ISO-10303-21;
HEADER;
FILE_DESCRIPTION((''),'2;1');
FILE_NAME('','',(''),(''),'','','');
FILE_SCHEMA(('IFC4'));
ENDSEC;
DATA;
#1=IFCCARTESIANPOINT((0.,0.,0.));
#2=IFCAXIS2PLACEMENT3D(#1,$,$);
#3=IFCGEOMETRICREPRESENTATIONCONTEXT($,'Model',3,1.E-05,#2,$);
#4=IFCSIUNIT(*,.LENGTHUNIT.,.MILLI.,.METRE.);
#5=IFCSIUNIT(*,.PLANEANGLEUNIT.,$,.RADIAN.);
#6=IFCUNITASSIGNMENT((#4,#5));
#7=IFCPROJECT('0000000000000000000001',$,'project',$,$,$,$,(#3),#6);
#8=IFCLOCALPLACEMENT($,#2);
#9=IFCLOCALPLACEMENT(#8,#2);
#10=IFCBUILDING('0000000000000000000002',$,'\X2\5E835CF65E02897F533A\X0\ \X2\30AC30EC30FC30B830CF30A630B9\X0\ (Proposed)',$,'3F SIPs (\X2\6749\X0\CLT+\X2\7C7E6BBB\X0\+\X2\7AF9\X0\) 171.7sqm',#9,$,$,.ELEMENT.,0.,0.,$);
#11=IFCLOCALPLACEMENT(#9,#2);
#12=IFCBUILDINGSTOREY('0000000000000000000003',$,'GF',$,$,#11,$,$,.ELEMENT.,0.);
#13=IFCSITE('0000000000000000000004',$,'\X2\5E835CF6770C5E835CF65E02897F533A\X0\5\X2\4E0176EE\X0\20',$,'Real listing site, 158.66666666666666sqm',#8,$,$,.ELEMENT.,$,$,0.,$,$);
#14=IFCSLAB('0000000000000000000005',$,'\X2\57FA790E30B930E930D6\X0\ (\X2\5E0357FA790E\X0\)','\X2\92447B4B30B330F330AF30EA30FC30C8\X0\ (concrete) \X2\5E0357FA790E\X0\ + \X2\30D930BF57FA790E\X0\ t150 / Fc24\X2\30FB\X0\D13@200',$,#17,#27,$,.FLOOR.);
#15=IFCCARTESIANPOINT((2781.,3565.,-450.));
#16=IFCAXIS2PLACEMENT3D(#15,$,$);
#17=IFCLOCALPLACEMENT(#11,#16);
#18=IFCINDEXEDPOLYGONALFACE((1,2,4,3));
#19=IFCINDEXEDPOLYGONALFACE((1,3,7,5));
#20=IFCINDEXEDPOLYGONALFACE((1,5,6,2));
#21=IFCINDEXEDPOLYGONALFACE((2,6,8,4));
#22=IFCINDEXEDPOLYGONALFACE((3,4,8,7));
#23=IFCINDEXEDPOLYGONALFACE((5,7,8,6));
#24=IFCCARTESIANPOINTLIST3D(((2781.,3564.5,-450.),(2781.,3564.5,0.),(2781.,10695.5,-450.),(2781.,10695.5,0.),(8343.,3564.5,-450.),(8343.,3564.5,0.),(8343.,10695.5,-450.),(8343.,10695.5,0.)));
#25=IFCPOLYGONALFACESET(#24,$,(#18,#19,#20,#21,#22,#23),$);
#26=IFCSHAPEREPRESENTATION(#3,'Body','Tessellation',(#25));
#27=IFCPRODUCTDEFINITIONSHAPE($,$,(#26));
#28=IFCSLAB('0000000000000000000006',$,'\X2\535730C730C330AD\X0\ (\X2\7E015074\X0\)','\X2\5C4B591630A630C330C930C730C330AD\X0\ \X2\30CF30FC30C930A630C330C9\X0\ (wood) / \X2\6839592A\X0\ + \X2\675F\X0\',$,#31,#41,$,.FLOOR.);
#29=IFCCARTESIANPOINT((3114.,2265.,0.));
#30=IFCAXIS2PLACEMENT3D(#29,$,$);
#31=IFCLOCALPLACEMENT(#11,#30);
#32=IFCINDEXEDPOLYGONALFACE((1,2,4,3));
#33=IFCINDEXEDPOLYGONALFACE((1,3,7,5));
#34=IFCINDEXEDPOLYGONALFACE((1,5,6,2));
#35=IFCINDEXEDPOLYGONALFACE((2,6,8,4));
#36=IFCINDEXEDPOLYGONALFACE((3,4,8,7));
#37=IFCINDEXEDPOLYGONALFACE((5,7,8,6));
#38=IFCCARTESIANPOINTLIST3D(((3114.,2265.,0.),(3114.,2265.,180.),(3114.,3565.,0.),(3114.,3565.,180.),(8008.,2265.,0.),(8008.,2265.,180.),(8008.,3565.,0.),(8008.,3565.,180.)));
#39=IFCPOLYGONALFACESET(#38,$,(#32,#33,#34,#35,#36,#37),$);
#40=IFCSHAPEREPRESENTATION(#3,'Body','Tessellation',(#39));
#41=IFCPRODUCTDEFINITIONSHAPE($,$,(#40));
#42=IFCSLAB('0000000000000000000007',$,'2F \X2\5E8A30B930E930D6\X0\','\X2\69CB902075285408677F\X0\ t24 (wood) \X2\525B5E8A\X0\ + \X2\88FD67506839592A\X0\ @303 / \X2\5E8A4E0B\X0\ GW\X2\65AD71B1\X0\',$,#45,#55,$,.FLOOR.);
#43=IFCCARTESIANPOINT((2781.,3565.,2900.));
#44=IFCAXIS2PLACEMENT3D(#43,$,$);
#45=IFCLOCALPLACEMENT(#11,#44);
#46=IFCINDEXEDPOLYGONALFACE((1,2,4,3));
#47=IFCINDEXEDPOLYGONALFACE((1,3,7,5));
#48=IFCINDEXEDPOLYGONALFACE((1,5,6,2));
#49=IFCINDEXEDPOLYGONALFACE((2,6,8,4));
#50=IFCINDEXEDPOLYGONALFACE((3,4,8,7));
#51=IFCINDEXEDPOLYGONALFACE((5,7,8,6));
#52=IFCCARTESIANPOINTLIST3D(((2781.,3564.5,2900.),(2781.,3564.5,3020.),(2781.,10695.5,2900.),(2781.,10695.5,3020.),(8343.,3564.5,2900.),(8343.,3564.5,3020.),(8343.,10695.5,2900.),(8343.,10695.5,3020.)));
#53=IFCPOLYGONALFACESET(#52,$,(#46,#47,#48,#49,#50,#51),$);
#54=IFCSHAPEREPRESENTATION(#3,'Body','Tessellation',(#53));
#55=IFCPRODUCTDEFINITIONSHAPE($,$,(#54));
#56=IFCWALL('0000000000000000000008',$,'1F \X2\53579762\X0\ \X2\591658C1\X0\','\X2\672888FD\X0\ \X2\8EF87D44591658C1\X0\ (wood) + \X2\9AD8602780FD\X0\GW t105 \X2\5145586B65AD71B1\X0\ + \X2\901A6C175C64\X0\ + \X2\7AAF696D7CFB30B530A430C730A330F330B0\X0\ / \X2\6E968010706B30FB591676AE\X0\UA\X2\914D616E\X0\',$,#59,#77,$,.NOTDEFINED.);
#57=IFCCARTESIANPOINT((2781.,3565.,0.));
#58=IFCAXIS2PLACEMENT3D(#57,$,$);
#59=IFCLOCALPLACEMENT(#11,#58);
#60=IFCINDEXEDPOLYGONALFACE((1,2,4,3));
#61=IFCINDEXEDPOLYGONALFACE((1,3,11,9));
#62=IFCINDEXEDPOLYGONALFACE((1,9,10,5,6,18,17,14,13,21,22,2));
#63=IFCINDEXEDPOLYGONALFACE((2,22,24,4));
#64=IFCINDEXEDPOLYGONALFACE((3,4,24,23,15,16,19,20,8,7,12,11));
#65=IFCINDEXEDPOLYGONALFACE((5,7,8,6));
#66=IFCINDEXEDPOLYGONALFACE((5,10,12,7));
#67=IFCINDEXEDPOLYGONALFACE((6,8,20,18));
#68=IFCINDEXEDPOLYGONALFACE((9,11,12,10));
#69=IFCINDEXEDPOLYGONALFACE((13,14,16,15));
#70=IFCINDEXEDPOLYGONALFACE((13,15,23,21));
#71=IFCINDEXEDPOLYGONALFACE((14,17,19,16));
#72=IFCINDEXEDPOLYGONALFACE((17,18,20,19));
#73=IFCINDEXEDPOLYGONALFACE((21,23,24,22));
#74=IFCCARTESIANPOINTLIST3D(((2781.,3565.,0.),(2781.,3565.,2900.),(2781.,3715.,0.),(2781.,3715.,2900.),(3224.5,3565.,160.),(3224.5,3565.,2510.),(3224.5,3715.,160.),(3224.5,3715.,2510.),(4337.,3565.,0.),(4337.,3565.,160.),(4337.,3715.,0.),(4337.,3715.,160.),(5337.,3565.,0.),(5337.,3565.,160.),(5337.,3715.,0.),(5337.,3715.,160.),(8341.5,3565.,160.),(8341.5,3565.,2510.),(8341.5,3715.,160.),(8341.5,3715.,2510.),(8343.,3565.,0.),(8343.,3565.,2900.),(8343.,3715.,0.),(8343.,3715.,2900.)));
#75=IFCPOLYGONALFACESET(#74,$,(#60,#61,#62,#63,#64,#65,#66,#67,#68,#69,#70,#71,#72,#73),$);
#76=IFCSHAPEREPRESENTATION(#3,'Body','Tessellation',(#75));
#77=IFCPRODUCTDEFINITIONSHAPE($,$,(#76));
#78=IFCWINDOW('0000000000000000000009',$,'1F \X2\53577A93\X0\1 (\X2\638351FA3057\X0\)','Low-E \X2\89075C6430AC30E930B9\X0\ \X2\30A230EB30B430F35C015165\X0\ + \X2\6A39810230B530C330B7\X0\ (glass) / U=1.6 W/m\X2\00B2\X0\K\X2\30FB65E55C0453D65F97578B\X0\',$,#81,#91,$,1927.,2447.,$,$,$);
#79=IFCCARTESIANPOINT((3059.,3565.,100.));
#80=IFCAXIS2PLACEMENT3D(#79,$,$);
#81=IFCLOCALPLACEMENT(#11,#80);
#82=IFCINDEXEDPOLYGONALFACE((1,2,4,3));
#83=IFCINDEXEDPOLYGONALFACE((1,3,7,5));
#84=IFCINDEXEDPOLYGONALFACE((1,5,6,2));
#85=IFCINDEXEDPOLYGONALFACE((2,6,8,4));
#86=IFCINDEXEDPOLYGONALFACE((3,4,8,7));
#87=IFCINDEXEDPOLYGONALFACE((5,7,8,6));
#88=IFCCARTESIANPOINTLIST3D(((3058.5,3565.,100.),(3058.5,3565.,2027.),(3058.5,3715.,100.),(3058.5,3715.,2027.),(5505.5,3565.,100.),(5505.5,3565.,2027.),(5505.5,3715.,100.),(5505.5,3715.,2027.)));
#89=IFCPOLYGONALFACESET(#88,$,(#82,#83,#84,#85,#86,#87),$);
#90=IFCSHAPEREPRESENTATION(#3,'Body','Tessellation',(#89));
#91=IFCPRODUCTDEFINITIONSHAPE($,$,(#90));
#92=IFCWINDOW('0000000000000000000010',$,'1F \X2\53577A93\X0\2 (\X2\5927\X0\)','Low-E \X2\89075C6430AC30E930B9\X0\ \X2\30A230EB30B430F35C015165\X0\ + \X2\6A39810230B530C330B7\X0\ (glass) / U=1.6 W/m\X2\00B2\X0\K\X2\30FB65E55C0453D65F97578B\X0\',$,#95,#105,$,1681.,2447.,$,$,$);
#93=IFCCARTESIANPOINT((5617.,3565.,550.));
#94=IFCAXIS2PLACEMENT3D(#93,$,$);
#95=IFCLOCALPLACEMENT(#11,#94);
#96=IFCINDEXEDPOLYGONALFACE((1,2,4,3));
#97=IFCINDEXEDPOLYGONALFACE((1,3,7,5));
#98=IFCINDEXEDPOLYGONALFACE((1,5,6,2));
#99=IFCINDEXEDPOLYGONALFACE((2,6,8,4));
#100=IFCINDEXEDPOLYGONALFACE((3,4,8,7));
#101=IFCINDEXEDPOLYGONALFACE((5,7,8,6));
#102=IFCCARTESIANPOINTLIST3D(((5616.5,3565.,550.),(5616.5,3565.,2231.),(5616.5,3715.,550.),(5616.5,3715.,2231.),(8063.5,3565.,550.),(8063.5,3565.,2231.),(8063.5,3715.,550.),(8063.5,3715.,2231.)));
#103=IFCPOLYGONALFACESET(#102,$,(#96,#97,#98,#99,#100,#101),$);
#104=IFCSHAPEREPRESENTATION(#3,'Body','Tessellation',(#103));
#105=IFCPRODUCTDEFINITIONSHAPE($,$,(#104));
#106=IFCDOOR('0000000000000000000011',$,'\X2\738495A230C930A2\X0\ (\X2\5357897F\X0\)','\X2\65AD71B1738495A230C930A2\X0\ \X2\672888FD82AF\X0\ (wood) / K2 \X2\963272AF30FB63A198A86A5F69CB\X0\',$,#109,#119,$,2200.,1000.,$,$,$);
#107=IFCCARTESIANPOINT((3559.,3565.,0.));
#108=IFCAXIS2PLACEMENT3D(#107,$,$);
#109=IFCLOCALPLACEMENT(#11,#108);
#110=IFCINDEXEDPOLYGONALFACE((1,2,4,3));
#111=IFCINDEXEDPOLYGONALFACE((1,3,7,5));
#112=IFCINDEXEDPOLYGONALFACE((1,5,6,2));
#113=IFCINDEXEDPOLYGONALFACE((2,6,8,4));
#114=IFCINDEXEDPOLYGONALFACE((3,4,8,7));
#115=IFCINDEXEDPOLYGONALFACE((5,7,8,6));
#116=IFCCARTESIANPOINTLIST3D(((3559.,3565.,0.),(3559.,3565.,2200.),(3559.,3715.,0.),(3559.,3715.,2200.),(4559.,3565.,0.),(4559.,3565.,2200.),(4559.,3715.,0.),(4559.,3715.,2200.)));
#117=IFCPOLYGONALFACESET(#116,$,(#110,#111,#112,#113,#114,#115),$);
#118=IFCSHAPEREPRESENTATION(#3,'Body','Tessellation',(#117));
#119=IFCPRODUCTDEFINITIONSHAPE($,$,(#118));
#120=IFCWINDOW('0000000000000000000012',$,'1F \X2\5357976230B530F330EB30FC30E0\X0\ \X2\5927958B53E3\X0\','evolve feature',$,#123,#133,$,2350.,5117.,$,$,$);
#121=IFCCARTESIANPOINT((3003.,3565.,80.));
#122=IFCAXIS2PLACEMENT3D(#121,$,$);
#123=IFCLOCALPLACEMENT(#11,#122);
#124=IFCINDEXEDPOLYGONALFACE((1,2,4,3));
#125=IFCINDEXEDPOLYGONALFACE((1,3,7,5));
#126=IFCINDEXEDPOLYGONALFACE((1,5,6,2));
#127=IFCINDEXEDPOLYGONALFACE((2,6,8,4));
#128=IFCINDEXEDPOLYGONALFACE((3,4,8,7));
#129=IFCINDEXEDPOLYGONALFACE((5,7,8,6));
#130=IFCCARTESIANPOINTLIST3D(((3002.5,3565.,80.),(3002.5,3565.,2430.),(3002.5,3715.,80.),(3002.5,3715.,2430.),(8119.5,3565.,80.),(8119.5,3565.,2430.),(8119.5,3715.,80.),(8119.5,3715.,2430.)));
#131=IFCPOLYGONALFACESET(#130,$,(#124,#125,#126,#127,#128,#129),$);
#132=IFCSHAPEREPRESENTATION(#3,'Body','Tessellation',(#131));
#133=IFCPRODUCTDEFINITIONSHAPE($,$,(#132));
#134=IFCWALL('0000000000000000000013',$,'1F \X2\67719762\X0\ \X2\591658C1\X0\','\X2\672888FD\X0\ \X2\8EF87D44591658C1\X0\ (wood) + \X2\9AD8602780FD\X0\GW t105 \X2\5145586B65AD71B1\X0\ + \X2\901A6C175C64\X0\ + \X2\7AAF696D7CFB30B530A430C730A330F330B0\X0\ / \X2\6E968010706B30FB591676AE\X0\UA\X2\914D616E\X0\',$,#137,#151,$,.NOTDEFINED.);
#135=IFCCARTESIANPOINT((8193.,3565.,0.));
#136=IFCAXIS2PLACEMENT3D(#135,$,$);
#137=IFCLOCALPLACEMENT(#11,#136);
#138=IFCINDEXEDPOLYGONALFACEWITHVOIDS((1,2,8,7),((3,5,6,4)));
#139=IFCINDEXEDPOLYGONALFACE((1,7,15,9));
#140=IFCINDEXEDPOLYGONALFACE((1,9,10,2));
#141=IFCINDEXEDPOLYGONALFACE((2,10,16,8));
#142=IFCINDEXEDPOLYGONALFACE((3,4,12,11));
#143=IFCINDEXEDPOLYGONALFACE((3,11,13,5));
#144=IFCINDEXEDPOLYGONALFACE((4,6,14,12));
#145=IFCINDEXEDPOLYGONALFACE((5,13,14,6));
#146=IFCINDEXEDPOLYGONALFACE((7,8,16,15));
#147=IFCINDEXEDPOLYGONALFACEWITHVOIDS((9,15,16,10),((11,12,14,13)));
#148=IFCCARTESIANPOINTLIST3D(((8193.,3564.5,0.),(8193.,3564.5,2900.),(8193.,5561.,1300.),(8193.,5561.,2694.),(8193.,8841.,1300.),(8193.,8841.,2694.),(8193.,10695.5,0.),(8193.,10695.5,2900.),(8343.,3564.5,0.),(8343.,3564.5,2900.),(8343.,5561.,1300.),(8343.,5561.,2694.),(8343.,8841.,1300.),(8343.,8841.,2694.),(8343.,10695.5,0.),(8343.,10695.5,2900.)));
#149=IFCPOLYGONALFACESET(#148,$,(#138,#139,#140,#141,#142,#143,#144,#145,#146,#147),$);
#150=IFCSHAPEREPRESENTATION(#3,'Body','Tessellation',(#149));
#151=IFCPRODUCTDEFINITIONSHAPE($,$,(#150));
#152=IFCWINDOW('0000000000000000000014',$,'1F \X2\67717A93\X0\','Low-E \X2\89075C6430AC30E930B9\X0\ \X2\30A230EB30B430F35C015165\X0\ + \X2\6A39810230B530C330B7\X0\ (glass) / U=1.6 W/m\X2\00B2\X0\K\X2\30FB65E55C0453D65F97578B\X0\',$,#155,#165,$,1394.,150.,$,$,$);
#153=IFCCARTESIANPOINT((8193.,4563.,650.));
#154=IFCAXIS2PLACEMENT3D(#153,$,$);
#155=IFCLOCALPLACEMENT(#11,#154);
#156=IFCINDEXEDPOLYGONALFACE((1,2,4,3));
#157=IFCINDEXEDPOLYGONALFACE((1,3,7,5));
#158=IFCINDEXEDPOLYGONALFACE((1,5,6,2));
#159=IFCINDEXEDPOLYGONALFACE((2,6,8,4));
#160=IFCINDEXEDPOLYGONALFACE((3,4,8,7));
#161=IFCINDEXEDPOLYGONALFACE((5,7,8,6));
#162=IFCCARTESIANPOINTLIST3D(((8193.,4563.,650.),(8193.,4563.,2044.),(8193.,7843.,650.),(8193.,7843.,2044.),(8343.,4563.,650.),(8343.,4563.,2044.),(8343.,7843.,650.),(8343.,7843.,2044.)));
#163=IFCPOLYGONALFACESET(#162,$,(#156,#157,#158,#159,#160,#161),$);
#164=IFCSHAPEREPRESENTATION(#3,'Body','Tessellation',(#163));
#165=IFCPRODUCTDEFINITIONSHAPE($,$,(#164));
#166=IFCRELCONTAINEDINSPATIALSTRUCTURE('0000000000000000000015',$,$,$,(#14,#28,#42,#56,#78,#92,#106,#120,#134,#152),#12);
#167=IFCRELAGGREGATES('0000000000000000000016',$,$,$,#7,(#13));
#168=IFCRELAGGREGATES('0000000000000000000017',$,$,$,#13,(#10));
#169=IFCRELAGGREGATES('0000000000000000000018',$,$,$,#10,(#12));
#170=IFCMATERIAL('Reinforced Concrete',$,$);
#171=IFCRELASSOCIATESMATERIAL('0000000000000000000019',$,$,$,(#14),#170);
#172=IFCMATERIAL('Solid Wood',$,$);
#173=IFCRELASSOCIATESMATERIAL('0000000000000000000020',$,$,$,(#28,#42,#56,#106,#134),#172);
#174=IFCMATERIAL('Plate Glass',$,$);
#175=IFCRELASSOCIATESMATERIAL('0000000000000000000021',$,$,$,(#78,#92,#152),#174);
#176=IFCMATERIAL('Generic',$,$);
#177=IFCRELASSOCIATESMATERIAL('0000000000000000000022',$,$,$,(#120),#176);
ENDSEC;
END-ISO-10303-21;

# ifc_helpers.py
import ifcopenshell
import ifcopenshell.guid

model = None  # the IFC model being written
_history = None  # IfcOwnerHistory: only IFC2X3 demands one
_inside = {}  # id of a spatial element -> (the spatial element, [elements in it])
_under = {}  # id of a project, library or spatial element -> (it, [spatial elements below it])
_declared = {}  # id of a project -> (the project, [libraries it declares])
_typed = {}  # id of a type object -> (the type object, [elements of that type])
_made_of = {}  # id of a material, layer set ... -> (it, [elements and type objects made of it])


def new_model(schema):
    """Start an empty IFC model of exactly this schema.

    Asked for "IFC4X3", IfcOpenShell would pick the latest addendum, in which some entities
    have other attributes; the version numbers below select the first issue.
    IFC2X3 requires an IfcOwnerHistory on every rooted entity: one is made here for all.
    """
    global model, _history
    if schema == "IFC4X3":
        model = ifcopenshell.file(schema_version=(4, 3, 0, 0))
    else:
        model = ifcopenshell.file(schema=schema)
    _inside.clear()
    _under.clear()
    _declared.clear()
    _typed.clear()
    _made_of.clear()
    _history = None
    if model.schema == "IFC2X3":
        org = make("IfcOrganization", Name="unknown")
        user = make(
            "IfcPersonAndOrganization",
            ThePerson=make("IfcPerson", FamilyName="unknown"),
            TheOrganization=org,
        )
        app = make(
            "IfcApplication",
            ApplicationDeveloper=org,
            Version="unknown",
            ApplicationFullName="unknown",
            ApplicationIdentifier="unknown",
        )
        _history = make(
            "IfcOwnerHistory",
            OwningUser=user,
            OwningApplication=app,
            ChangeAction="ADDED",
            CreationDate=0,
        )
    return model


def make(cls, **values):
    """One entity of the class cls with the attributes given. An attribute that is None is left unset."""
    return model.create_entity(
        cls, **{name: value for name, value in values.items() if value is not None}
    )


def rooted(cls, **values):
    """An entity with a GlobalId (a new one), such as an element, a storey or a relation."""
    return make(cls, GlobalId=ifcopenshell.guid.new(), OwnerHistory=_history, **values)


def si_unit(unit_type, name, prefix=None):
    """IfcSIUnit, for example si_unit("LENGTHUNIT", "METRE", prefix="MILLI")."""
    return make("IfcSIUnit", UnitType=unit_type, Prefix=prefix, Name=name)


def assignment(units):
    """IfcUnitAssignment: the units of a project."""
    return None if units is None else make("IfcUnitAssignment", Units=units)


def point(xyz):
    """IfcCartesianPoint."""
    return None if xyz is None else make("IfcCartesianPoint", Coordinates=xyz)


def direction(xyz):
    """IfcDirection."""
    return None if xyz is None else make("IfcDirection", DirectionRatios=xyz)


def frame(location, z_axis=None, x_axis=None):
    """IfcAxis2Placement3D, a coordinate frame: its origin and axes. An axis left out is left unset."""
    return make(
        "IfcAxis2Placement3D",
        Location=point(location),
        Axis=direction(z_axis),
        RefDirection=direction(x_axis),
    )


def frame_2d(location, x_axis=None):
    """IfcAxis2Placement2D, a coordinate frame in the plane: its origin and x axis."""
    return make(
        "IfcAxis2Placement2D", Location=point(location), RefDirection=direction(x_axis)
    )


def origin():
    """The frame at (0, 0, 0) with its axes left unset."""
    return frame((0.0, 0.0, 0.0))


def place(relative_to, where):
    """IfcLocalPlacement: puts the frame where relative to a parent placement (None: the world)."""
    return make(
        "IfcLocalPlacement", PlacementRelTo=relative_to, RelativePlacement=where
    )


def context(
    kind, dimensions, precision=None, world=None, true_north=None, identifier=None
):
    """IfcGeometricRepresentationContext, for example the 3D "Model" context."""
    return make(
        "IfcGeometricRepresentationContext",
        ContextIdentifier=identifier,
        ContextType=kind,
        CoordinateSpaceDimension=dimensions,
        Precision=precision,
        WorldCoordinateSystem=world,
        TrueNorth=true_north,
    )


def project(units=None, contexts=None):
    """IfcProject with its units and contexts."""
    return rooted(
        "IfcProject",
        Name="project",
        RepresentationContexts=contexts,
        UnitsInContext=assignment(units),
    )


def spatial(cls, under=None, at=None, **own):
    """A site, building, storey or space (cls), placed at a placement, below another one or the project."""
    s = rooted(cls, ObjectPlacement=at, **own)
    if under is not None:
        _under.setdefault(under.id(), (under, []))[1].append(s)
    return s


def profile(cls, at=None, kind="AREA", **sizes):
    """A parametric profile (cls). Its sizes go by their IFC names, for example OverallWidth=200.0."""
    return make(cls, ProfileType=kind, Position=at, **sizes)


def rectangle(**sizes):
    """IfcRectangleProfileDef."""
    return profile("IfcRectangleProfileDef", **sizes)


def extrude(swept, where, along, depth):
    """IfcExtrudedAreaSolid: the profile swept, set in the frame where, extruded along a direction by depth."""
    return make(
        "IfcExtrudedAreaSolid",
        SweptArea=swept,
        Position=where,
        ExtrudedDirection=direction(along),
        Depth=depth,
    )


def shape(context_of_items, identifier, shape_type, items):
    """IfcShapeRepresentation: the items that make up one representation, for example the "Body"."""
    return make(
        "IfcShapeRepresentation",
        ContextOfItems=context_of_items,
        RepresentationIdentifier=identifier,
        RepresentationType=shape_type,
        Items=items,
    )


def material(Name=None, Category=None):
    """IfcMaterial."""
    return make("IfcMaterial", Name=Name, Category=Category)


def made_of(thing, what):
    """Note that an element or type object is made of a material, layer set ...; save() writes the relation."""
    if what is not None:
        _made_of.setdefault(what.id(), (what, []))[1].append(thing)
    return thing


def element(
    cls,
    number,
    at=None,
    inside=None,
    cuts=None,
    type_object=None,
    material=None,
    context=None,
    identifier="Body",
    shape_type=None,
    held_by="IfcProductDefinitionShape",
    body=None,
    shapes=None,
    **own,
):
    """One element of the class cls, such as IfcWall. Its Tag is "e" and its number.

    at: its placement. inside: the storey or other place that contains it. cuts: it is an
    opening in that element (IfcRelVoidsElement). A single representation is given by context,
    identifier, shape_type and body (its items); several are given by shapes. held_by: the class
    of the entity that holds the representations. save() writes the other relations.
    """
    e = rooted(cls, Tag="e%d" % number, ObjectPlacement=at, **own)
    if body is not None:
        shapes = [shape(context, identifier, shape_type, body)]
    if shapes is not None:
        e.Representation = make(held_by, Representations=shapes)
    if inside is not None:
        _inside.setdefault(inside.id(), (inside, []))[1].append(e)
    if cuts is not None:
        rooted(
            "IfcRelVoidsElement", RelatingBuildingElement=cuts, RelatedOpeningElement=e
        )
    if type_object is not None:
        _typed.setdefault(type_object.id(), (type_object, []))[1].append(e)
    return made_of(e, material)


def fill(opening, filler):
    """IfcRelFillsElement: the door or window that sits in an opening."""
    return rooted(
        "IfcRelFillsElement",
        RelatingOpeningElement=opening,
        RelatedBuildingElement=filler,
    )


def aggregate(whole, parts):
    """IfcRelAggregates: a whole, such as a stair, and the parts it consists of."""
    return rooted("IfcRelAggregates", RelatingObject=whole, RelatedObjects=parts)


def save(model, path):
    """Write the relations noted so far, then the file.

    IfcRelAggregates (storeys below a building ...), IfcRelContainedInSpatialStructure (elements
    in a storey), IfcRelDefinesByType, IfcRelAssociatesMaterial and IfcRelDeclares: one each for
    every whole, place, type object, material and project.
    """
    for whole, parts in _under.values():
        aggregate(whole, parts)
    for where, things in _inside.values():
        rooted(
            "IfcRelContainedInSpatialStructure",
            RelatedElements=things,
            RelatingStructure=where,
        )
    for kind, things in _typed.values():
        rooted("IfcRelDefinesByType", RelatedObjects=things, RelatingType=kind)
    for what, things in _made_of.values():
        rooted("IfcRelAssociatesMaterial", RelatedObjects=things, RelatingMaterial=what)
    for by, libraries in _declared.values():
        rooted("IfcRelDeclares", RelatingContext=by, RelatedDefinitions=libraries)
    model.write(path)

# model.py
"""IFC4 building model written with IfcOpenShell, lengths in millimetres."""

from ifc_helpers import new_model, si_unit, frame, frame_2d, origin, place, context, project, spatial, rectangle, extrude, material, element, fill, save


model = new_model("IFC4")

# Units and contexts
model_context = context("Model", 3, precision=1e-05, world=origin())
ifc_project = project(units=[si_unit("LENGTHUNIT", "METRE", prefix="MILLI"), si_unit("PLANEANGLEUNIT", "RADIAN")], contexts=[model_context])

# Site, building, storey
site_placement = place(None, origin())
site = spatial("IfcSite", under=ifc_project, at=site_placement, Name="広島県広島市西区5丁目20", ObjectType="Real listing site, 158.66666666666666sqm", CompositionType="ELEMENT", RefElevation=0.0)
building_placement = place(site_placement, origin())
building = spatial("IfcBuilding", under=site, at=building_placement, Name="広島市西区 ガレージハウス (Proposed)", ObjectType="3F SIPs (杉CLT+籾殻+竹) 171.7sqm", CompositionType="ELEMENT", ElevationOfRefHeight=0.0, ElevationOfTerrain=0.0)
storey_placement = place(building_placement, origin())
storey = spatial("IfcBuildingStorey", under=building, at=storey_placement, Name="GF", CompositionType="ELEMENT", Elevation=0.0)

# Slabs
ifc_material_1 = material(Name="Reinforced Concrete")
slab_1_placement = place(storey_placement, frame((2781.0, 3565.0, -450.0)))
element("IfcSlab", 1, at=slab_1_placement, inside=storey, material=ifc_material_1, Name="基礎スラブ (布基礎)", Description="鉄筋コンクリート (concrete) 布基礎 + ベタ基礎 t150 / Fc24・D13@200", PredefinedType="FLOOR", context=model_context, shape_type="SweptSolid", body=[
    extrude(rectangle(XDim=5562.0, YDim=7131.0, at=frame_2d((2781.0, 3565.0))), frame((2781.0, 3565.0, -450.0)), (0.0, 0.0, 1.0), 450.0),
])
ifc_material_2 = material(Name="Solid Wood")
slab_2_placement = place(storey_placement, frame((3114.0, 2265.0, 0.0)))
element("IfcSlab", 2, at=slab_2_placement, inside=storey, material=ifc_material_2, Name="南デッキ (縁側)", Description="屋外ウッドデッキ ハードウッド (wood) / 根太 + 束", PredefinedType="FLOOR", context=model_context, shape_type="SweptSolid", body=[
    extrude(rectangle(XDim=4894.0, YDim=1300.0, at=frame_2d((2447.0, 650.0))), frame((3114.0, 2265.0, 0.0)), (0.0, 0.0, 1.0), 180.0),
])
slab_3_placement = place(storey_placement, frame((2781.0, 3565.0, 2900.0)))
element("IfcSlab", 3, at=slab_3_placement, inside=storey, material=ifc_material_2, Name="2F 床スラブ", Description="構造用合板 t24 (wood) 剛床 + 製材根太 @303 / 床下 GW断熱", PredefinedType="FLOOR", context=model_context, shape_type="SweptSolid", body=[
    extrude(rectangle(XDim=5562.0, YDim=7131.0, at=frame_2d((2781.0, 3565.0))), frame((2781.0, 3565.0, 2900.0)), (0.0, 0.0, 1.0), 120.0),
])

# Wall, openings, windows, door
wall_1_placement = place(storey_placement, frame((2781.0, 3565.0, 0.0)))
wall_1 = element("IfcWall", 4, at=wall_1_placement, inside=storey, material=ifc_material_2, Name="1F 南面 外壁", Description="木製 軸組外壁 (wood) + 高性能GW t105 充填断熱 + 通気層 + 窯業系サイディング / 準耐火・外皮UA配慮", PredefinedType="NOTDEFINED", context=model_context, shape_type="SweptSolid", body=[
    extrude(rectangle(XDim=5562.0, YDim=150.0, at=frame_2d((2781.0, 75.0))), frame((2781.0, 3565.0, 0.0)), (0.0, 0.0, 1.0), 2900.0),
])
opening_1_placement = place(storey_placement, frame((3059.0, 3565.0, 100.0)))
opening_1 = element("IfcOpeningElement", 5, at=opening_1_placement, cuts=wall_1, PredefinedType="NOTDEFINED", context=model_context, shape_type="SweptSolid", body=[
    extrude(rectangle(XDim=2447.0, YDim=150.0, at=frame_2d((1223.0, 75.0))), frame((3059.0, 3565.0, 100.0)), (0.0, 0.0, 1.0), 1927.0),
])
opening_2_placement = place(storey_placement, frame((5617.0, 3565.0, 550.0)))
opening_2 = element("IfcOpeningElement", 6, at=opening_2_placement, cuts=wall_1, PredefinedType="NOTDEFINED", context=model_context, shape_type="SweptSolid", body=[
    extrude(rectangle(XDim=2447.0, YDim=150.0, at=frame_2d((1223.0, 75.0))), frame((5617.0, 3565.0, 550.0)), (0.0, 0.0, 1.0), 1681.0),
])
opening_3_placement = place(storey_placement, frame((3559.0, 3565.0, 0.0)))
opening_3 = element("IfcOpeningElement", 7, at=opening_3_placement, cuts=wall_1, PredefinedType="NOTDEFINED", context=model_context, shape_type="SweptSolid", body=[
    extrude(rectangle(XDim=1000.0, YDim=150.0, at=frame_2d((500.0, 75.0))), frame((3559.0, 3565.0, 0.0)), (0.0, 0.0, 1.0), 2200.0),
])
opening_4_placement = place(storey_placement, frame((3003.0, 3565.0, 80.0)))
opening_4 = element("IfcOpeningElement", 8, at=opening_4_placement, cuts=wall_1, PredefinedType="NOTDEFINED", context=model_context, shape_type="SweptSolid", body=[
    extrude(rectangle(XDim=5117.0, YDim=150.0, at=frame_2d((2558.0, 75.0))), frame((3003.0, 3565.0, 80.0)), (0.0, 0.0, 1.0), 2350.0),
])
ifc_material_3 = material(Name="Plate Glass")
window_1_placement = place(storey_placement, frame((3059.0, 3565.0, 100.0)))
window_1 = element("IfcWindow", 9, at=window_1_placement, inside=storey, material=ifc_material_3, Name="1F 南窓1 (掃出し)", Description="Low-E 複層ガラス アルゴン封入 + 樹脂サッシ (glass) / U=1.6 W/m²K・日射取得型", OverallHeight=1927.0, OverallWidth=2447.0, context=model_context, shape_type="SweptSolid", body=[
    extrude(rectangle(XDim=2447.0, YDim=150.0, at=frame_2d((1223.0, 75.0))), frame((3059.0, 3565.0, 100.0)), (0.0, 0.0, 1.0), 1927.0),
])
fill(opening_1, window_1)
window_2_placement = place(storey_placement, frame((5617.0, 3565.0, 550.0)))
window_2 = element("IfcWindow", 10, at=window_2_placement, inside=storey, material=ifc_material_3, Name="1F 南窓2 (大)", Description="Low-E 複層ガラス アルゴン封入 + 樹脂サッシ (glass) / U=1.6 W/m²K・日射取得型", OverallHeight=1681.0, OverallWidth=2447.0, context=model_context, shape_type="SweptSolid", body=[
    extrude(rectangle(XDim=2447.0, YDim=150.0, at=frame_2d((1223.0, 75.0))), frame((5617.0, 3565.0, 550.0)), (0.0, 0.0, 1.0), 1681.0),
])
fill(opening_2, window_2)
door_placement = place(storey_placement, frame((3559.0, 3565.0, 0.0)))
door = element("IfcDoor", 11, at=door_placement, inside=storey, material=ifc_material_2, Name="玄関ドア (南西)", Description="断熱玄関ドア 木製芯 (wood) / K2 防犯・採風機構", OverallHeight=2200.0, OverallWidth=1000.0, context=model_context, shape_type="SweptSolid", body=[
    extrude(rectangle(XDim=1000.0, YDim=150.0, at=frame_2d((500.0, 75.0))), frame((3559.0, 3565.0, 0.0)), (0.0, 0.0, 1.0), 2200.0),
])
fill(opening_3, door)
ifc_material_4 = material(Name="Generic")
window_3_placement = place(storey_placement, frame((3003.0, 3565.0, 80.0)))
window_3 = element("IfcWindow", 12, at=window_3_placement, inside=storey, material=ifc_material_4, Name="1F 南面サンルーム 大開口", Description="evolve feature", OverallHeight=2350.0, OverallWidth=5117.0, context=model_context, shape_type="SweptSolid", body=[
    extrude(rectangle(XDim=5117.0, YDim=150.0, at=frame_2d((2558.0, 75.0))), frame((3003.0, 3565.0, 80.0)), (0.0, 0.0, 1.0), 2350.0),
])
fill(opening_4, window_3)

# Wall, opening, window
wall_2_placement = place(storey_placement, frame((8193.0, 3565.0, 0.0)))
wall_2 = element("IfcWall", 13, at=wall_2_placement, inside=storey, material=ifc_material_2, Name="1F 東面 外壁", Description="木製 軸組外壁 (wood) + 高性能GW t105 充填断熱 + 通気層 + 窯業系サイディング / 準耐火・外皮UA配慮", PredefinedType="NOTDEFINED", context=model_context, shape_type="SweptSolid", body=[
    extrude(rectangle(XDim=150.0, YDim=7131.0, at=frame_2d((75.0, 3565.0))), frame((8193.0, 3565.0, 0.0)), (0.0, 0.0, 1.0), 2900.0),
])
opening_5_placement = place(storey_placement, frame((8193.0, 4563.0, 650.0)))
opening_5 = element("IfcOpeningElement", 14, at=opening_5_placement, cuts=wall_2, PredefinedType="NOTDEFINED", context=model_context, shape_type="SweptSolid", body=[
    extrude(rectangle(XDim=150.0, YDim=3280.0, at=frame_2d((75.0, 1640.0))), frame((8193.0, 4563.0, 650.0)), (0.0, 0.0, 1.0), 1394.0),
])
window_4_placement = place(storey_placement, frame((8193.0, 4563.0, 650.0)))
window_4 = element("IfcWindow", 15, at=window_4_placement, inside=storey, material=ifc_material_3, Name="1F 東窓", Description="Low-E 複層ガラス アルゴン封入 + 樹脂サッシ (glass) / U=1.6 W/m²K・日射取得型", OverallHeight=1394.0, OverallWidth=150.0, context=model_context, shape_type="SweptSolid", body=[
    extrude(rectangle(XDim=150.0, YDim=3280.0, at=frame_2d((75.0, 1640.0))), frame((8193.0, 4563.0, 650.0)), (0.0, 0.0, 1.0), 1394.0),
])
fill(opening_5, window_4)

save(model, "model.ifc")
